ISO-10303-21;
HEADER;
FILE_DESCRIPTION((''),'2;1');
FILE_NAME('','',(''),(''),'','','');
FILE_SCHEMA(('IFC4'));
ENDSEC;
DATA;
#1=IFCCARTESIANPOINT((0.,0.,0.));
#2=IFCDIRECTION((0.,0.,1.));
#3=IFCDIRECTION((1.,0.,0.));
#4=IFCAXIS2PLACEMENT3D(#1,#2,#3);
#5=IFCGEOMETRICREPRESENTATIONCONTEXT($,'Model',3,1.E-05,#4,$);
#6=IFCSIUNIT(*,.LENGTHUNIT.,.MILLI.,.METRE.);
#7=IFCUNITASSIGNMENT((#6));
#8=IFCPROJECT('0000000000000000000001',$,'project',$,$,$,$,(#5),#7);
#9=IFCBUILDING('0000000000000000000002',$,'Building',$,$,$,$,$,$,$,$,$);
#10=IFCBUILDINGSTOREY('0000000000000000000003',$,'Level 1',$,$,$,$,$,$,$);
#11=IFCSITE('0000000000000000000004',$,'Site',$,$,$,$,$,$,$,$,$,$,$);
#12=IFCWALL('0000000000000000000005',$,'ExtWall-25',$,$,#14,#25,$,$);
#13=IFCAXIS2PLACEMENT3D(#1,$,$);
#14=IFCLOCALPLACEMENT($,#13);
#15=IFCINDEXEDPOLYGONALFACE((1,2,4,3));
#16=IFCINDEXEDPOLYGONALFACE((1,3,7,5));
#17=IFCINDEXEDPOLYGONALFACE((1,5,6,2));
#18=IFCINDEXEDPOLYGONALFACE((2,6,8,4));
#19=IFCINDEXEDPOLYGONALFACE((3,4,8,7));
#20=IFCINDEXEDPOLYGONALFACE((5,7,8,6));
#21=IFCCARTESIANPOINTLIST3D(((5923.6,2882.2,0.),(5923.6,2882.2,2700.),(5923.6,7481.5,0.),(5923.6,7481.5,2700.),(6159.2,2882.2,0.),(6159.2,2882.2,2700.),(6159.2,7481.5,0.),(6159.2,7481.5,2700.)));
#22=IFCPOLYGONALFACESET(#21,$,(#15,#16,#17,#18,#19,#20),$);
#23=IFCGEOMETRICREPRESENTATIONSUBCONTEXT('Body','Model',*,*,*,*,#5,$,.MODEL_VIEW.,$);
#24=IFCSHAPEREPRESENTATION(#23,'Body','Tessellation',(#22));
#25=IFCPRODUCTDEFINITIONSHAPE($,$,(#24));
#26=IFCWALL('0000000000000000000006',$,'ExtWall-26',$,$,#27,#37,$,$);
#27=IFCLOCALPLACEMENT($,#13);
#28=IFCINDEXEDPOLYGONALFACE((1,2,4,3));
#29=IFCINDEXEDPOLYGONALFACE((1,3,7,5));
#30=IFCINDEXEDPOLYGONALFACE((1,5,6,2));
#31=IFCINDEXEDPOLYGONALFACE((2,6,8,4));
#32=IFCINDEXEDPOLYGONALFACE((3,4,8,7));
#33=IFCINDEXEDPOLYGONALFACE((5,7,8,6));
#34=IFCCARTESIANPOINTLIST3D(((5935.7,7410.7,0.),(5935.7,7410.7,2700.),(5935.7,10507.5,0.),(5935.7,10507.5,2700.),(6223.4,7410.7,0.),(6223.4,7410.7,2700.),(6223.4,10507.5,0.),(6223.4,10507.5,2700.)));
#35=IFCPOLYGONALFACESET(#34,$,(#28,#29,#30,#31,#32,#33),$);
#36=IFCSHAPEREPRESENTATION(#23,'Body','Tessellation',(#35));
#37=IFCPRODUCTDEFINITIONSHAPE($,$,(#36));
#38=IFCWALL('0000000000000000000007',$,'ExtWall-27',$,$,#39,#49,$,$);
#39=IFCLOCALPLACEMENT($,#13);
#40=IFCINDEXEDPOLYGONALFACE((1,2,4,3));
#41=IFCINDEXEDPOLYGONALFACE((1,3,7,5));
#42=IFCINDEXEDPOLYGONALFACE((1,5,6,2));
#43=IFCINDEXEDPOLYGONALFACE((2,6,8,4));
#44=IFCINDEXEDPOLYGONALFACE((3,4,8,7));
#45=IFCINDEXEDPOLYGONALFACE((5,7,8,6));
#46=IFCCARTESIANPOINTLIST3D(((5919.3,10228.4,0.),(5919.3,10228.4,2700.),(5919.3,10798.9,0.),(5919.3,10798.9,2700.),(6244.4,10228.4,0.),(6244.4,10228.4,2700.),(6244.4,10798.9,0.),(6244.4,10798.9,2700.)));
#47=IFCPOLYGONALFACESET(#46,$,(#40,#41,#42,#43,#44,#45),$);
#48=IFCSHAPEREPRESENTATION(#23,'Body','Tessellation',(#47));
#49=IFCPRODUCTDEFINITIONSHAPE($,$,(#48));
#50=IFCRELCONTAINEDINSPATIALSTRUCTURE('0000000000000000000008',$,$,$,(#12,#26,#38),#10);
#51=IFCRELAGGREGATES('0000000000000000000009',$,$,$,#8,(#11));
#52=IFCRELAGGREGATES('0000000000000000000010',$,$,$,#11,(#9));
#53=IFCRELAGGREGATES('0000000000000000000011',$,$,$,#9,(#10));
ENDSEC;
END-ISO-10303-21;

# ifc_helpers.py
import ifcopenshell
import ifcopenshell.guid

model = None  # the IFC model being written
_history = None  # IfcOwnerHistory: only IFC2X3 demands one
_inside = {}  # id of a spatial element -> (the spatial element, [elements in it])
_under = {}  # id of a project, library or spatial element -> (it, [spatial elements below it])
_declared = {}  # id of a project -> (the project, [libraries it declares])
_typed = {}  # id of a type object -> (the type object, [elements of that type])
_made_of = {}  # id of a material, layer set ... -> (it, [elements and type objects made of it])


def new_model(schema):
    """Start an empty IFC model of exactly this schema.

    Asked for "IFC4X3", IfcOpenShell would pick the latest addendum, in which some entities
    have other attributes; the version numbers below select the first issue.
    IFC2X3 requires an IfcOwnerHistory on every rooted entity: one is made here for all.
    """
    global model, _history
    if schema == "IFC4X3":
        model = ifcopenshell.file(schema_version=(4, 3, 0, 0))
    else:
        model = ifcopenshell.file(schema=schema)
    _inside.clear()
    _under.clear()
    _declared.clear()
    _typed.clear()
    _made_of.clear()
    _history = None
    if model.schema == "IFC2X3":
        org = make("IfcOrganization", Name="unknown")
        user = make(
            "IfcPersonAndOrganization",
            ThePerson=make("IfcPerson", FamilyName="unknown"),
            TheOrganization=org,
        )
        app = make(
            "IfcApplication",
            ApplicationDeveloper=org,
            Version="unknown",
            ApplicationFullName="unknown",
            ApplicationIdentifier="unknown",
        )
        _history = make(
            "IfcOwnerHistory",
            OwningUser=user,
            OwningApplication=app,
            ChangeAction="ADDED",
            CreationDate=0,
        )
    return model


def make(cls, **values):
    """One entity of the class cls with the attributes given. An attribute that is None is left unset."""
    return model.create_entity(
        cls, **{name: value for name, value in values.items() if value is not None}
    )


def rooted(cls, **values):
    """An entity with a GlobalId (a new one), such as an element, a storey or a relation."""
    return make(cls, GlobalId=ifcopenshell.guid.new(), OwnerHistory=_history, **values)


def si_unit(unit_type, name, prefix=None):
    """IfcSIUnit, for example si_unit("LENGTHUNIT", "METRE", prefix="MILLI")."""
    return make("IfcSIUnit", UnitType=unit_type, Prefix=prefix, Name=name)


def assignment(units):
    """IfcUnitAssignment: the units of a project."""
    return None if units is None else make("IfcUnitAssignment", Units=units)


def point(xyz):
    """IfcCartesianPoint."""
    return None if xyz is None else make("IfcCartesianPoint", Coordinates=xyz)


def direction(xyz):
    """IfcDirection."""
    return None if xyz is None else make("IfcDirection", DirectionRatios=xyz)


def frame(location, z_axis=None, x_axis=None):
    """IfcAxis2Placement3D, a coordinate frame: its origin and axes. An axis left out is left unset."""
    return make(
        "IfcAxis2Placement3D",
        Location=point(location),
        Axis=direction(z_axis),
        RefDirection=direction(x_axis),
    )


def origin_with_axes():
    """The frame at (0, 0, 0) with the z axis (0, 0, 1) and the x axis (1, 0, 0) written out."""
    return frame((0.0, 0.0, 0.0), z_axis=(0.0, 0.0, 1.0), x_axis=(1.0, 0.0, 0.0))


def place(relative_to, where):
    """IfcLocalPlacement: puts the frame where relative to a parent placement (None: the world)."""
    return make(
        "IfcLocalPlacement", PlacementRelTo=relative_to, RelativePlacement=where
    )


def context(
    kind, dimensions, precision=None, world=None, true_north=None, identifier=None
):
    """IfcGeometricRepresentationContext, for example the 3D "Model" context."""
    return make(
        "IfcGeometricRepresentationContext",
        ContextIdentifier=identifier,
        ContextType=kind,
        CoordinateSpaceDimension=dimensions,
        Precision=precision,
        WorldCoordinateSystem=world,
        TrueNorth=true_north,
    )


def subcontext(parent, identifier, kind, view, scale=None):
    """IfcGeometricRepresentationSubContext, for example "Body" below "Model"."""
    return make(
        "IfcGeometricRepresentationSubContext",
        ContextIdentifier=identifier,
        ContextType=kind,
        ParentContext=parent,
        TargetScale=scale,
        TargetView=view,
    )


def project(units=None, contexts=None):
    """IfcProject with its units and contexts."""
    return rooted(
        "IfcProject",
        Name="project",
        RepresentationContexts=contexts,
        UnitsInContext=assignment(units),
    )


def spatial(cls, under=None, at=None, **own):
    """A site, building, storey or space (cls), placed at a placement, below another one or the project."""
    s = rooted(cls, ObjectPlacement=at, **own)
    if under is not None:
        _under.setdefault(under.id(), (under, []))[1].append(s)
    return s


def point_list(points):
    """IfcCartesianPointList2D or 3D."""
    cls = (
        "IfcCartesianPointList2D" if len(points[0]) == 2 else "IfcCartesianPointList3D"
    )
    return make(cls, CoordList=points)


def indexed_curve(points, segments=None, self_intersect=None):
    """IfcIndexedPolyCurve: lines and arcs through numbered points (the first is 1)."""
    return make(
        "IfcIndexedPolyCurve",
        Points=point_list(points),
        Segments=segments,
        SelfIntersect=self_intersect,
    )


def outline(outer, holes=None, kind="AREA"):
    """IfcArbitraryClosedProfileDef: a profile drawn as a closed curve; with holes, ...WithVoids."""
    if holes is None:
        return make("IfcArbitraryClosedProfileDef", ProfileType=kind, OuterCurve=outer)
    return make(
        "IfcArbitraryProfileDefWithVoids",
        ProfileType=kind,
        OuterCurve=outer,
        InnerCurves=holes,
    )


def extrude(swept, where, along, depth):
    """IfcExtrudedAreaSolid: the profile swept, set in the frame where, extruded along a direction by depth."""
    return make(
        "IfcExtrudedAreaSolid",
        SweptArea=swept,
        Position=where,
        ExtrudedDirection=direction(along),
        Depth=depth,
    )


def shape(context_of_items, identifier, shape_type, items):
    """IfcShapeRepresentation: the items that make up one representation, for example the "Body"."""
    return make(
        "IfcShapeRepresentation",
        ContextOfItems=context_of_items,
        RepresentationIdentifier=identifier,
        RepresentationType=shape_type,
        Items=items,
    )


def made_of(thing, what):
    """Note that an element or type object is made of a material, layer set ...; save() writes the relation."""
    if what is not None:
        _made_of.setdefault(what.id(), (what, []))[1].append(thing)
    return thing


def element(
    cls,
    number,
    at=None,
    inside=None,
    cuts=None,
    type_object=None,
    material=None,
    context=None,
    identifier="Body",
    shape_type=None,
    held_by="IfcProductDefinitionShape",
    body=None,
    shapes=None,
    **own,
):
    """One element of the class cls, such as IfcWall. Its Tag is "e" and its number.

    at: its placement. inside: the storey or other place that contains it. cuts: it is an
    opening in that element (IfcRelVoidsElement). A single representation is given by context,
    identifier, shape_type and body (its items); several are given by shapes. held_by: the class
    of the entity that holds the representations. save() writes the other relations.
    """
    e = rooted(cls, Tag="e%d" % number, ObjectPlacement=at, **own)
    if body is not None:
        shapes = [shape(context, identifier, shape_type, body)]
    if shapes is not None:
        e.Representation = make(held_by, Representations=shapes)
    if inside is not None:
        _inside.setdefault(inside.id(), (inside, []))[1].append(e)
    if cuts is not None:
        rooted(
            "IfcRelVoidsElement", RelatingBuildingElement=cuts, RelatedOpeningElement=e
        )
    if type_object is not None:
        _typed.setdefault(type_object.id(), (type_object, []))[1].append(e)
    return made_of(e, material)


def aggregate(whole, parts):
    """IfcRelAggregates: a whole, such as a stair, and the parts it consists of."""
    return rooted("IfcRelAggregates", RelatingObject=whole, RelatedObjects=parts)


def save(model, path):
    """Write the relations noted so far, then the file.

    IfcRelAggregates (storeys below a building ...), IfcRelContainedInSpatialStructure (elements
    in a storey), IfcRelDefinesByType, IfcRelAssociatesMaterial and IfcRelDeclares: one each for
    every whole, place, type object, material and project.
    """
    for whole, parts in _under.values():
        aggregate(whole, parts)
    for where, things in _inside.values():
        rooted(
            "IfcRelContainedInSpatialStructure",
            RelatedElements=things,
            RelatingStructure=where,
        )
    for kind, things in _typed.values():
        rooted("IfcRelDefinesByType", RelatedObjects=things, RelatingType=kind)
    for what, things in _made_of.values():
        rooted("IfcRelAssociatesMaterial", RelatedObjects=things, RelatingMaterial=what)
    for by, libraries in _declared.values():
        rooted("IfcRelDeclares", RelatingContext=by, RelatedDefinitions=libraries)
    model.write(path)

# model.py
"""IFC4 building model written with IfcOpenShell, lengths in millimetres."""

from ifc_helpers import new_model, si_unit, frame, origin_with_axes, place, context, subcontext, project, spatial, indexed_curve, outline, extrude, element, save


model = new_model("IFC4")

# Units and contexts
model_context = context("Model", 3, precision=1e-05, world=origin_with_axes())
body_context = subcontext(model_context, "Body", "Model", "MODEL_VIEW")
ifc_project = project(units=[si_unit("LENGTHUNIT", "METRE", prefix="MILLI")], contexts=[model_context])

# Site, building, storey
site = spatial("IfcSite", under=ifc_project, Name="Site")
building = spatial("IfcBuilding", under=site, Name="Building")
storey = spatial("IfcBuildingStorey", under=building, Name="Level 1")

# Walls
wall_1_placement = place(None, frame((6041.4, 2882.2, 0.0), z_axis=(0.0, 0.0, 1.0), x_axis=(0.0, 1.0, 0.0)))
element("IfcWall", 1, at=wall_1_placement, inside=storey, Name="ExtWall-25", context=body_context, shape_type="SweptSolid", body=[
    extrude(outline(indexed_curve([(0.0, 0.0), (0.0, 235.6), (4599.3, 235.6), (4599.3, 0.0), (0.0, 0.0)], self_intersect=False)), frame((0.0, -117.8, 0.0), z_axis=(0.0, 0.0, 1.0), x_axis=(1.0, 0.0, 0.0)), (0.0, 0.0, 1.0), 2700.0),
])
wall_2_placement = place(None, frame((6079.5, 7410.7, 0.0), z_axis=(0.0, 0.0, 1.0), x_axis=(0.0, 1.0, 0.0)))
element("IfcWall", 2, at=wall_2_placement, inside=storey, Name="ExtWall-26", context=body_context, shape_type="SweptSolid", body=[
    extrude(outline(indexed_curve([(0.0, 0.0), (0.0, 287.7), (3096.8, 287.7), (3096.8, 0.0), (0.0, 0.0)], self_intersect=False)), frame((0.0, -143.9, 0.0), z_axis=(0.0, 0.0, 1.0), x_axis=(1.0, 0.0, 0.0)), (0.0, 0.0, 1.0), 2700.0),
])
wall_3_placement = place(None, frame((6081.8, 10228.4, 0.0), z_axis=(0.0, 0.0, 1.0), x_axis=(0.0, 1.0, 0.0)))
element("IfcWall", 3, at=wall_3_placement, inside=storey, Name="ExtWall-27", context=body_context, shape_type="SweptSolid", body=[
    extrude(outline(indexed_curve([(0.0, 0.0), (0.0, 325.1), (570.5, 325.1), (570.5, 0.0), (0.0, 0.0)], self_intersect=False)), frame((0.0, -162.5, 0.0), z_axis=(0.0, 0.0, 1.0), x_axis=(1.0, 0.0, 0.0)), (0.0, 0.0, 1.0), 2700.0),
])

save(model, "model.ifc")
